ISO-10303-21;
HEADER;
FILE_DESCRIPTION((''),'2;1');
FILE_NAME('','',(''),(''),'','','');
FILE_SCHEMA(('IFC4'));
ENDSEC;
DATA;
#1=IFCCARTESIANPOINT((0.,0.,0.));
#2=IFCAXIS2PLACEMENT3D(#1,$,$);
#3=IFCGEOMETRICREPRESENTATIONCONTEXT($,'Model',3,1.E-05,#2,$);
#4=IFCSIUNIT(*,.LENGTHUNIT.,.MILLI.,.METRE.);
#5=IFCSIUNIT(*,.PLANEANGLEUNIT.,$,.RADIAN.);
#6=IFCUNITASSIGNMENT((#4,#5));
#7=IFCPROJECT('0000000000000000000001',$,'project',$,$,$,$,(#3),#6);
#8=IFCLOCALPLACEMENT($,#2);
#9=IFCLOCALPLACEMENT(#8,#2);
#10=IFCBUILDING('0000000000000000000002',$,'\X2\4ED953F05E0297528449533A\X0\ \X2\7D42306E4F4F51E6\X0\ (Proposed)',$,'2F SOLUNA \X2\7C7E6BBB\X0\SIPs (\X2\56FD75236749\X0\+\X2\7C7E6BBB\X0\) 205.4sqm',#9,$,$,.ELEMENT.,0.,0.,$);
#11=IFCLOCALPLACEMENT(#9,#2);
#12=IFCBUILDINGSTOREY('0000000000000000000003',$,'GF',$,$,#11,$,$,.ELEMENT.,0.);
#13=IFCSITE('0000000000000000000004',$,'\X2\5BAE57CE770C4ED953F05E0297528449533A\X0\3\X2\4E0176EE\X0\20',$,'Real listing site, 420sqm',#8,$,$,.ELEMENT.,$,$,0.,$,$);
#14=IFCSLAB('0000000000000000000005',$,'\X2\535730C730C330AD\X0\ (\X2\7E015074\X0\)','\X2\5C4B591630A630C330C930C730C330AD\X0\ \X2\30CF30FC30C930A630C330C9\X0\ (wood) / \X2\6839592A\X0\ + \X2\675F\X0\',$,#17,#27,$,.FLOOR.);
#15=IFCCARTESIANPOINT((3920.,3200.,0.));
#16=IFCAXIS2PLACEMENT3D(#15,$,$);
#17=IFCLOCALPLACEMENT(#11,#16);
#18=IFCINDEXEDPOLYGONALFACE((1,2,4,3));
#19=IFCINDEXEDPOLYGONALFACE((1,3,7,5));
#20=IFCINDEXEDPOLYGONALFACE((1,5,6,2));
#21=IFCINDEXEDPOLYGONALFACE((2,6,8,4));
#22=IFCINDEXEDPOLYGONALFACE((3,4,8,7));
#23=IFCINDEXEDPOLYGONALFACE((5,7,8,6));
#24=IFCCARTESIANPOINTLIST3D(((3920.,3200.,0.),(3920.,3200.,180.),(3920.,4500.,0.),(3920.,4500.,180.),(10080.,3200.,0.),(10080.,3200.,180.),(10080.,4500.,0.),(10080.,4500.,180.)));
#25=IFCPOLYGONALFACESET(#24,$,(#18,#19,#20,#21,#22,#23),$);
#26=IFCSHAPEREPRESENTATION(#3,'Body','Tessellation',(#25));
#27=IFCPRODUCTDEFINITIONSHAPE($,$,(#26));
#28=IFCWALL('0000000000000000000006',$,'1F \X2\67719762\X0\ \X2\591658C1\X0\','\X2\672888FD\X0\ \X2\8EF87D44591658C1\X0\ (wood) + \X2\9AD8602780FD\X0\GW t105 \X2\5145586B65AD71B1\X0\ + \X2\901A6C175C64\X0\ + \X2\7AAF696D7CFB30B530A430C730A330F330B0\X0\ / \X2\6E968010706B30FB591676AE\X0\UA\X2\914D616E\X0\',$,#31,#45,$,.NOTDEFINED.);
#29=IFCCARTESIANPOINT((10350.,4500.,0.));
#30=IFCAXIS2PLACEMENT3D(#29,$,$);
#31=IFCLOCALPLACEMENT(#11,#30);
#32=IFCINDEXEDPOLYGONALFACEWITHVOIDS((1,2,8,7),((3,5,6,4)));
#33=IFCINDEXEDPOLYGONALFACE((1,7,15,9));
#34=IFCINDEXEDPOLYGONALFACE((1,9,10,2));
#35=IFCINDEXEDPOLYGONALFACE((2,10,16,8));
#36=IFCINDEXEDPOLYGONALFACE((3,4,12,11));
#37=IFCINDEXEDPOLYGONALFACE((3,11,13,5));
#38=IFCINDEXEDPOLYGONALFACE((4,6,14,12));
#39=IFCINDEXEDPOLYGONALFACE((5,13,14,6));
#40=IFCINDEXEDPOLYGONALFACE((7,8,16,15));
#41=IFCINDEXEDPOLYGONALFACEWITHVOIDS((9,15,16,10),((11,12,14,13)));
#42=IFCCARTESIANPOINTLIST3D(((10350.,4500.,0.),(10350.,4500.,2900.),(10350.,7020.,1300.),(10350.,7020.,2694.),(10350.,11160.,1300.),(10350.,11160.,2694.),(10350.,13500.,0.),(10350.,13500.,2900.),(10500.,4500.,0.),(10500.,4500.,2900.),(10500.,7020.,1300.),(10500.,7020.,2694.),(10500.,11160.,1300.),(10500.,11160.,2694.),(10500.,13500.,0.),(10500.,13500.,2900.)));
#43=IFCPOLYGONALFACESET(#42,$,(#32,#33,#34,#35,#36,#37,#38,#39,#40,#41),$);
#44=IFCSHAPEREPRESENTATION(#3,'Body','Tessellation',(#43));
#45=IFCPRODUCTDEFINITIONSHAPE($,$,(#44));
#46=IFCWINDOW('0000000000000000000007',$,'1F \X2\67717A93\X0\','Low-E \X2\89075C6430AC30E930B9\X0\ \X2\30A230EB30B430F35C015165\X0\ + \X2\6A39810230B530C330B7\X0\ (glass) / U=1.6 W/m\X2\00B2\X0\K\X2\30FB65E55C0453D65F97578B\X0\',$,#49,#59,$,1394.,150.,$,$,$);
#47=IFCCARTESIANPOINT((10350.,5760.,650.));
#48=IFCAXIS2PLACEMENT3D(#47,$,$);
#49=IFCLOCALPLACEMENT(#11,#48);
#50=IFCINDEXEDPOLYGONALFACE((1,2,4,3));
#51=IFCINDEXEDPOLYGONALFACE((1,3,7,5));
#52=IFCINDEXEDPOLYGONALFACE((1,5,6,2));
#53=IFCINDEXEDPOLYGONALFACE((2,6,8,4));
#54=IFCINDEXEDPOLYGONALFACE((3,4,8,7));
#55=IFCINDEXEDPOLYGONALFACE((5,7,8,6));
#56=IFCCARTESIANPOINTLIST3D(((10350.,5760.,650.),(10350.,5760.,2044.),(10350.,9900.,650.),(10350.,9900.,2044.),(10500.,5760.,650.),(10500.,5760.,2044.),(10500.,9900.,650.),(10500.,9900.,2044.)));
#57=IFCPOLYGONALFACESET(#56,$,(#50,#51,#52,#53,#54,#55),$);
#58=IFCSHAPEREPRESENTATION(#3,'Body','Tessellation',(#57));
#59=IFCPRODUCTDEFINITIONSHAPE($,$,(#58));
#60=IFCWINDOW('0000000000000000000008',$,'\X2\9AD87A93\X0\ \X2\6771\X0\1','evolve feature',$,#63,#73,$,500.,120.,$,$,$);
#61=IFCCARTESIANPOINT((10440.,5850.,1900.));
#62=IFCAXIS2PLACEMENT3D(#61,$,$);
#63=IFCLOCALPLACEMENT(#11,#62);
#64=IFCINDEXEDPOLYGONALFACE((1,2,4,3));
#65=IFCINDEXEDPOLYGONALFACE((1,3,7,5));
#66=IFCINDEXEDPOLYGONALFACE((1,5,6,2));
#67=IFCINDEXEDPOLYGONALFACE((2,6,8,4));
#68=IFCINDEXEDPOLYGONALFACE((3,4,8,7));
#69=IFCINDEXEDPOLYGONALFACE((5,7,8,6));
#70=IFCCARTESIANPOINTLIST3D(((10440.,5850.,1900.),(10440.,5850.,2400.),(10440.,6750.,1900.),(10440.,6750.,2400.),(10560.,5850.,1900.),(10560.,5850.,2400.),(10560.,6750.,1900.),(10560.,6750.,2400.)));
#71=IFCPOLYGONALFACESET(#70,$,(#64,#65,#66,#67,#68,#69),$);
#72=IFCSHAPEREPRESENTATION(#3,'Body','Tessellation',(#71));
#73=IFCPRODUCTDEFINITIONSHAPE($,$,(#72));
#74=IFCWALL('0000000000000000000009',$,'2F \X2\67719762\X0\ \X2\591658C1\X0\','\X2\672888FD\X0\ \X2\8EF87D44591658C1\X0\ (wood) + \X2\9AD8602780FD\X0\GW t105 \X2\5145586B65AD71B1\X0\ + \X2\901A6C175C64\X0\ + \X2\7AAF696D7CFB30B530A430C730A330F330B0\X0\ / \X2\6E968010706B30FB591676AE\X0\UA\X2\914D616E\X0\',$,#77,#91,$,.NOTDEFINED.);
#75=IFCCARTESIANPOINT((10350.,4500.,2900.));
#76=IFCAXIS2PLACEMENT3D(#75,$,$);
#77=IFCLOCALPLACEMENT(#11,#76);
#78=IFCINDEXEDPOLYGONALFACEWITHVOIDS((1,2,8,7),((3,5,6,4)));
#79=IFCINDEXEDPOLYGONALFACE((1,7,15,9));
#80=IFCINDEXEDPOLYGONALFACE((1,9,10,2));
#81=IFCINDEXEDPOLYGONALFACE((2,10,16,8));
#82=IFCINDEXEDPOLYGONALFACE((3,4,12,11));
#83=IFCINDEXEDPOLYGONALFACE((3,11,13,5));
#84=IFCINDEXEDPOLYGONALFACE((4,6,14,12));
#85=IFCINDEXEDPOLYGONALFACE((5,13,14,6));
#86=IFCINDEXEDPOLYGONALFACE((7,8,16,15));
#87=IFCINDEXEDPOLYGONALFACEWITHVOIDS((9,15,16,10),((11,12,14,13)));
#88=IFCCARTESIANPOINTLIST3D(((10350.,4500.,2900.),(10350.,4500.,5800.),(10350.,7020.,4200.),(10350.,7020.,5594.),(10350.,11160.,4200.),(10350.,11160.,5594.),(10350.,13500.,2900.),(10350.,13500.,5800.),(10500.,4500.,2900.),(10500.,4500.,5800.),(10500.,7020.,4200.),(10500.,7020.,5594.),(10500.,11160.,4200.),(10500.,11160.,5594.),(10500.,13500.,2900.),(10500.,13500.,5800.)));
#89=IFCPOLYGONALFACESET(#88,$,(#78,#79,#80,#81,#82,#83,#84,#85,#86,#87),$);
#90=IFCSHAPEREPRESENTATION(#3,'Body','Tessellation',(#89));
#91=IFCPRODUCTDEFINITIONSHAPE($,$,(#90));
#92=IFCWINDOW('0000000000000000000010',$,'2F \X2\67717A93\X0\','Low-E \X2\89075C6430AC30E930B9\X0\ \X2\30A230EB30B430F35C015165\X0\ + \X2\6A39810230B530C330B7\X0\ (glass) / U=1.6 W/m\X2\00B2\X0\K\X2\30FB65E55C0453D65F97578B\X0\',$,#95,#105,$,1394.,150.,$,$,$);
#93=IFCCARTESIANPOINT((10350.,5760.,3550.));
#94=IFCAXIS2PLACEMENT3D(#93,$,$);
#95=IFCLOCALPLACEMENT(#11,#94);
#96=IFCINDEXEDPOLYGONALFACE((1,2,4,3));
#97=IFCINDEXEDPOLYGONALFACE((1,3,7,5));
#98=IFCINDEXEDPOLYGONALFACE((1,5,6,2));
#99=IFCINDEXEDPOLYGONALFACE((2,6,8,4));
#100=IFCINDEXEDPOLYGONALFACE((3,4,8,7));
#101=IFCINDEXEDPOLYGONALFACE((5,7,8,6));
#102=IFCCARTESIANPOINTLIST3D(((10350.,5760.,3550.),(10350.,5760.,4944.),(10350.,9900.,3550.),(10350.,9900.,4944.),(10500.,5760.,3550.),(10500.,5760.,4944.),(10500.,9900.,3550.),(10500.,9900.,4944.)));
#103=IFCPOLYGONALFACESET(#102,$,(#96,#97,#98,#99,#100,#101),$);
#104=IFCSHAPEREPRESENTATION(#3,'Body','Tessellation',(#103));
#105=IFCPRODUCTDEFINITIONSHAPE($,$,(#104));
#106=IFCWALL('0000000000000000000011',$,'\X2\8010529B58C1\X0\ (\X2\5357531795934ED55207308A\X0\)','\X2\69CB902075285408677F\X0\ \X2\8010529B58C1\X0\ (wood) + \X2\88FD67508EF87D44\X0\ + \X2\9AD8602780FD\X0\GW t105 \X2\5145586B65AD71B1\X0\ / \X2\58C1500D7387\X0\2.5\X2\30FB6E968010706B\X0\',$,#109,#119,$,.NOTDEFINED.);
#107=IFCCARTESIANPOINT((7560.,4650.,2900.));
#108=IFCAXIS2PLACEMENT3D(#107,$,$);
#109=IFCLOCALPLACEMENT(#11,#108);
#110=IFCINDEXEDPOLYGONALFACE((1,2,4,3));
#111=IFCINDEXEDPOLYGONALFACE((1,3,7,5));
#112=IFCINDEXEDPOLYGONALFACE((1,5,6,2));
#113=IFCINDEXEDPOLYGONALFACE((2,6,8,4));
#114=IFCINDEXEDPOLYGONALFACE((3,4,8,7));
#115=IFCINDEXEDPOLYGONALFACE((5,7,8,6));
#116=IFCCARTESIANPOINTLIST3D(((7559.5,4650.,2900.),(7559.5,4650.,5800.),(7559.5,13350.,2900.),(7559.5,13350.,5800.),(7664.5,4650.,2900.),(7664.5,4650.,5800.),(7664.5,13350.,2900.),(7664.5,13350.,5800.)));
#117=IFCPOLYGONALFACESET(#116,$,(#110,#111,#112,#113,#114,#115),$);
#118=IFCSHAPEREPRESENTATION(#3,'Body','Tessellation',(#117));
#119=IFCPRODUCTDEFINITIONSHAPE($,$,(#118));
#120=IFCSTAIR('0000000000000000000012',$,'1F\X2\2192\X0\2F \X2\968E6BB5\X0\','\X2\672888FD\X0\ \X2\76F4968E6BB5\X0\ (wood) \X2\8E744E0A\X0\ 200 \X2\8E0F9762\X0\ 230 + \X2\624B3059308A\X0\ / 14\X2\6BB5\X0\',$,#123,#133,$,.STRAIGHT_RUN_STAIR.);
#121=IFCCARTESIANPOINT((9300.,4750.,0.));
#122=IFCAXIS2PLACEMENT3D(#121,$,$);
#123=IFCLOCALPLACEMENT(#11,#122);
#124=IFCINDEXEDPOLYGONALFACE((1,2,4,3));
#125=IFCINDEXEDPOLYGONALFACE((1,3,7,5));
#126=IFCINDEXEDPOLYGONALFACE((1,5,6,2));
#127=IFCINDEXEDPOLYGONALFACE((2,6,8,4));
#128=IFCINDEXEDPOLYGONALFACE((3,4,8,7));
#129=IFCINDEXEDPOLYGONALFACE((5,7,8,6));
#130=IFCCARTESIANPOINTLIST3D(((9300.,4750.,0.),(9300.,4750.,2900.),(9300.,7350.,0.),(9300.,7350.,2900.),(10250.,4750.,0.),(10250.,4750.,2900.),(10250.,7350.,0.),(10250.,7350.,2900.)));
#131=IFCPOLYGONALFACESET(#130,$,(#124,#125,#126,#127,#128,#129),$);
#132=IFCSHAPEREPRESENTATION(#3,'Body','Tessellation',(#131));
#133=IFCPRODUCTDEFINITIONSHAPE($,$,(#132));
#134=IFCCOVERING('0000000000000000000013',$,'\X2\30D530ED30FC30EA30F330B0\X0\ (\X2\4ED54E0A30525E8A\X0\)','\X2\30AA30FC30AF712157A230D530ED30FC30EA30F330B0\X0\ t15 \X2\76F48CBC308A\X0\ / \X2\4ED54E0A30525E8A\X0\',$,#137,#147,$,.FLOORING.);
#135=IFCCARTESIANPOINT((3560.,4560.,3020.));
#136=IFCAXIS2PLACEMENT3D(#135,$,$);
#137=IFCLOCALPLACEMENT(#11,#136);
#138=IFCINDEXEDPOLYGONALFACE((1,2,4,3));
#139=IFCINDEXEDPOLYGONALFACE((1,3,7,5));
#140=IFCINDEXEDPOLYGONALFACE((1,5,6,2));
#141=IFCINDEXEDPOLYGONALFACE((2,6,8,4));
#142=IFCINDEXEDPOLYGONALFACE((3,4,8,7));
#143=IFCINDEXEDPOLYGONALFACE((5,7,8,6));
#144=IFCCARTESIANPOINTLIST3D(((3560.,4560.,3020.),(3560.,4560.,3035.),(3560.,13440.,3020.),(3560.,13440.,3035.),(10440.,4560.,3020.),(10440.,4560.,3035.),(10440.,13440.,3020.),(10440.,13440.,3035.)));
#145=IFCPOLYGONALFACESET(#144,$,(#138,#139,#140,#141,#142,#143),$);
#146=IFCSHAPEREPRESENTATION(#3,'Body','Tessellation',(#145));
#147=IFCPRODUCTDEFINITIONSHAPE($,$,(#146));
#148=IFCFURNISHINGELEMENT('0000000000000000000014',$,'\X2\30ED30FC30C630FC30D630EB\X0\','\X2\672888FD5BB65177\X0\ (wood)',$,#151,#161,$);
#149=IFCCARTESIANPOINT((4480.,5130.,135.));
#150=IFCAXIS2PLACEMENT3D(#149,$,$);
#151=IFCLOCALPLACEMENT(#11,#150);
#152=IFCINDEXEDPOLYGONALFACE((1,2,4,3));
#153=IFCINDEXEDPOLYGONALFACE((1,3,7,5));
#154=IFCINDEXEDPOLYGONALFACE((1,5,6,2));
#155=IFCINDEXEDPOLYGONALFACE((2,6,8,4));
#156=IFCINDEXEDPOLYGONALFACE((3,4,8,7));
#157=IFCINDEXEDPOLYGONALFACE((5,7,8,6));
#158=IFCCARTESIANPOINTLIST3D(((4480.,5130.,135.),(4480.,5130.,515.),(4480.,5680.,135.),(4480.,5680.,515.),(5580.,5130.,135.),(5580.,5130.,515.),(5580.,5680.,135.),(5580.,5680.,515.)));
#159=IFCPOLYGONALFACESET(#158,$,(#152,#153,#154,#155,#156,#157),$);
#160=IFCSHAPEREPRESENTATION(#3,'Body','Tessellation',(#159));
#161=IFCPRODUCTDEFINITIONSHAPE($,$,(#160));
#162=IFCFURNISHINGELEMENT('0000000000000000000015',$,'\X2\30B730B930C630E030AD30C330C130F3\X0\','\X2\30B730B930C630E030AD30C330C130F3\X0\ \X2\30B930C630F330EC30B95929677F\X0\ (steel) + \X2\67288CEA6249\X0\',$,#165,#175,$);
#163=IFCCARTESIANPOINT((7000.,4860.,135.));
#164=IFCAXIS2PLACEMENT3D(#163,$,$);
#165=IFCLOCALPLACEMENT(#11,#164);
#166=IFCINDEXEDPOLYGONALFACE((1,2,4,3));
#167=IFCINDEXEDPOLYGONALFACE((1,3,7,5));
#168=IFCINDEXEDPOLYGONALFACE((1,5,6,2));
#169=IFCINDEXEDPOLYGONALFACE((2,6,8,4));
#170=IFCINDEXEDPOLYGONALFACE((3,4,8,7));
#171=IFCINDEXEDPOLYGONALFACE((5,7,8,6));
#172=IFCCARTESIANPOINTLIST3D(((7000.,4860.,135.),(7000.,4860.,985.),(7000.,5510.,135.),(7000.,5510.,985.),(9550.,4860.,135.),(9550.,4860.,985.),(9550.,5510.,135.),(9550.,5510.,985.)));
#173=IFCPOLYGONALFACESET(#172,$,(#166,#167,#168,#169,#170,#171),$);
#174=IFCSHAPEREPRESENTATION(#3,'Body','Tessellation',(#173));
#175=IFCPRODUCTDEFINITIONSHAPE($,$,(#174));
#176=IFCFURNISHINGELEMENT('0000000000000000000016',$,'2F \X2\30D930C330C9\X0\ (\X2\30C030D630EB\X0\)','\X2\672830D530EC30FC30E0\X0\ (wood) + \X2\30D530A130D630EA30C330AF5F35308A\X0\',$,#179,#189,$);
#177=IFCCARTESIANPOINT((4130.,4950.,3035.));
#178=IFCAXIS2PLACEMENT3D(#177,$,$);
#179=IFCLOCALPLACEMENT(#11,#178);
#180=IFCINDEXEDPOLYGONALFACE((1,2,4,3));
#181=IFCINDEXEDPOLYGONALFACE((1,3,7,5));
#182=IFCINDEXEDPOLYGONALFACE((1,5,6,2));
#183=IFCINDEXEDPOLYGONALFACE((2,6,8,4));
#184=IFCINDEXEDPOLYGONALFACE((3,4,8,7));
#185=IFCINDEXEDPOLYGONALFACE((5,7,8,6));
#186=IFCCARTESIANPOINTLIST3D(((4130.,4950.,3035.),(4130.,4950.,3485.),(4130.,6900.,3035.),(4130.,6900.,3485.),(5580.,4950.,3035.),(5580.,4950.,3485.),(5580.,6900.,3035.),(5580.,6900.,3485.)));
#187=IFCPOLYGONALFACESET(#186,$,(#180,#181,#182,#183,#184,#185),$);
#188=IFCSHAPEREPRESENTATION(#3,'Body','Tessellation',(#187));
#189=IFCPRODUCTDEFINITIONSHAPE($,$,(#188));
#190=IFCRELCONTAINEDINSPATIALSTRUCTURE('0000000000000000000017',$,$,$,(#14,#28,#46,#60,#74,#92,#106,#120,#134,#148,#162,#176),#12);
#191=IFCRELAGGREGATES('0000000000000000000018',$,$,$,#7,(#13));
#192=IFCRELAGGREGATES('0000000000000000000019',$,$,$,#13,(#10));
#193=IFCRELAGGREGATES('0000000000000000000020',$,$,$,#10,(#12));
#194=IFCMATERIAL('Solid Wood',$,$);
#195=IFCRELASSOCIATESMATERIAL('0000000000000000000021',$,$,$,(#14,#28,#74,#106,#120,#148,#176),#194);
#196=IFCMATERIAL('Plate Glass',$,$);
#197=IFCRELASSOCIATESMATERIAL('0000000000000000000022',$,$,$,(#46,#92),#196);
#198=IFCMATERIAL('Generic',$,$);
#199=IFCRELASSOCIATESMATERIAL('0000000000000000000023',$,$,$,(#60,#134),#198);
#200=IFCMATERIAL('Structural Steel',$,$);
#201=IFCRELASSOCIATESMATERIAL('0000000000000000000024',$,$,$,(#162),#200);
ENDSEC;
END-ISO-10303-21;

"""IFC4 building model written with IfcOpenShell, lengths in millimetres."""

from ifc_helpers import new_model, si_unit, frame, frame_2d, origin, place, context, project, spatial, rectangle, extrude, material, element, fill, save


model = new_model("IFC4")

# Units and contexts
model_context = context("Model", 3, precision=1e-05, world=origin())
ifc_project = project(units=[si_unit("LENGTHUNIT", "METRE", prefix="MILLI"), si_unit("PLANEANGLEUNIT", "RADIAN")], contexts=[model_context])

# Site, building, storey
site_placement = place(None, origin())
site = spatial("IfcSite", under=ifc_project, at=site_placement, Name="宮城県仙台市青葉区3丁目20", ObjectType="Real listing site, 420sqm", CompositionType="ELEMENT", RefElevation=0.0)
building_placement = place(site_placement, origin())
building = spatial("IfcBuilding", under=site, at=building_placement, Name="仙台市青葉区 終の住処 (Proposed)", ObjectType="2F SOLUNA 籾殻SIPs (国産杉+籾殻) 205.4sqm", CompositionType="ELEMENT", ElevationOfRefHeight=0.0, ElevationOfTerrain=0.0)
storey_placement = place(building_placement, origin())
storey = spatial("IfcBuildingStorey", under=building, at=storey_placement, Name="GF", CompositionType="ELEMENT", Elevation=0.0)

# Slab
ifc_material_1 = material(Name="Solid Wood")
slab_placement = place(storey_placement, frame((3920.0, 3200.0, 0.0)))
element("IfcSlab", 1, at=slab_placement, inside=storey, material=ifc_material_1, Name="南デッキ (縁側)", Description="屋外ウッドデッキ ハードウッド (wood) / 根太 + 束", PredefinedType="FLOOR", context=model_context, shape_type="SweptSolid", body=[
    extrude(rectangle(XDim=6160.0, YDim=1300.0, at=frame_2d((3080.0, 650.0))), frame((3920.0, 3200.0, 0.0)), (0.0, 0.0, 1.0), 180.0),
])

# Wall, openings, windows
wall_1_placement = place(storey_placement, frame((10350.0, 4500.0, 0.0)))
wall_1 = element("IfcWall", 2, at=wall_1_placement, inside=storey, material=ifc_material_1, Name="1F 東面 外壁", Description="木製 軸組外壁 (wood) + 高性能GW t105 充填断熱 + 通気層 + 窯業系サイディング / 準耐火・外皮UA配慮", PredefinedType="NOTDEFINED", context=model_context, shape_type="SweptSolid", body=[
    extrude(rectangle(XDim=150.0, YDim=9000.0, at=frame_2d((75.0, 4500.0))), frame((10350.0, 4500.0, 0.0)), (0.0, 0.0, 1.0), 2900.0),
])
opening_1_placement = place(storey_placement, frame((10350.0, 5760.0, 650.0)))
opening_1 = element("IfcOpeningElement", 3, at=opening_1_placement, cuts=wall_1, PredefinedType="NOTDEFINED", context=model_context, shape_type="SweptSolid", body=[
    extrude(rectangle(XDim=150.0, YDim=4140.0, at=frame_2d((75.0, 2070.0))), frame((10350.0, 5760.0, 650.0)), (0.0, 0.0, 1.0), 1394.0),
])
opening_2_placement = place(storey_placement, frame((10440.0, 5850.0, 1900.0)))
opening_2 = element("IfcOpeningElement", 4, at=opening_2_placement, cuts=wall_1, PredefinedType="NOTDEFINED", context=model_context, shape_type="SweptSolid", body=[
    extrude(rectangle(XDim=120.0, YDim=900.0, at=frame_2d((60.0, 450.0))), frame((10440.0, 5850.0, 1900.0)), (0.0, 0.0, 1.0), 500.0),
])
ifc_material_2 = material(Name="Plate Glass")
window_1_placement = place(storey_placement, frame((10350.0, 5760.0, 650.0)))
window_1 = element("IfcWindow", 5, at=window_1_placement, inside=storey, material=ifc_material_2, Name="1F 東窓", Description="Low-E 複層ガラス アルゴン封入 + 樹脂サッシ (glass) / U=1.6 W/m²K・日射取得型", OverallHeight=1394.0, OverallWidth=150.0, context=model_context, shape_type="SweptSolid", body=[
    extrude(rectangle(XDim=150.0, YDim=4140.0, at=frame_2d((75.0, 2070.0))), frame((10350.0, 5760.0, 650.0)), (0.0, 0.0, 1.0), 1394.0),
])
fill(opening_1, window_1)
ifc_material_3 = material(Name="Generic")
window_2_placement = place(storey_placement, frame((10440.0, 5850.0, 1900.0)))
window_2 = element("IfcWindow", 6, at=window_2_placement, inside=storey, material=ifc_material_3, Name="高窓 東1", Description="evolve feature", OverallHeight=500.0, OverallWidth=120.0, context=model_context, shape_type="SweptSolid", body=[
    extrude(rectangle(XDim=120.0, YDim=900.0, at=frame_2d((60.0, 450.0))), frame((10440.0, 5850.0, 1900.0)), (0.0, 0.0, 1.0), 500.0),
])
fill(opening_2, window_2)

# Wall, opening, window
wall_2_placement = place(storey_placement, frame((10350.0, 4500.0, 2900.0)))
wall_2 = element("IfcWall", 7, at=wall_2_placement, inside=storey, material=ifc_material_1, Name="2F 東面 外壁", Description="木製 軸組外壁 (wood) + 高性能GW t105 充填断熱 + 通気層 + 窯業系サイディング / 準耐火・外皮UA配慮", PredefinedType="NOTDEFINED", context=model_context, shape_type="SweptSolid", body=[
    extrude(rectangle(XDim=150.0, YDim=9000.0, at=frame_2d((75.0, 4500.0))), frame((10350.0, 4500.0, 2900.0)), (0.0, 0.0, 1.0), 2900.0),
])
opening_3_placement = place(storey_placement, frame((10350.0, 5760.0, 3550.0)))
opening_3 = element("IfcOpeningElement", 8, at=opening_3_placement, cuts=wall_2, PredefinedType="NOTDEFINED", context=model_context, shape_type="SweptSolid", body=[
    extrude(rectangle(XDim=150.0, YDim=4140.0, at=frame_2d((75.0, 2070.0))), frame((10350.0, 5760.0, 3550.0)), (0.0, 0.0, 1.0), 1394.0),
])
window_3_placement = place(storey_placement, frame((10350.0, 5760.0, 3550.0)))
window_3 = element("IfcWindow", 9, at=window_3_placement, inside=storey, material=ifc_material_2, Name="2F 東窓", Description="Low-E 複層ガラス アルゴン封入 + 樹脂サッシ (glass) / U=1.6 W/m²K・日射取得型", OverallHeight=1394.0, OverallWidth=150.0, context=model_context, shape_type="SweptSolid", body=[
    extrude(rectangle(XDim=150.0, YDim=4140.0, at=frame_2d((75.0, 2070.0))), frame((10350.0, 5760.0, 3550.0)), (0.0, 0.0, 1.0), 1394.0),
])
fill(opening_3, window_3)

# Wall
wall_3_placement = place(storey_placement, frame((7560.0, 4650.0, 2900.0)))
element("IfcWall", 10, at=wall_3_placement, inside=storey, material=ifc_material_1, Name="耐力壁 (南北間仕切り)", Description="構造用合板 耐力壁 (wood) + 製材軸組 + 高性能GW t105 充填断熱 / 壁倍率2.5・準耐火", PredefinedType="NOTDEFINED", context=model_context, shape_type="SweptSolid", body=[
    extrude(rectangle(XDim=105.0, YDim=8700.0, at=frame_2d((52.0, 4350.0))), frame((7560.0, 4650.0, 2900.0)), (0.0, 0.0, 1.0), 2900.0),
])

# Stair
stair_placement = place(storey_placement, frame((9300.0, 4750.0, 0.0)))
element("IfcStair", 11, at=stair_placement, inside=storey, material=ifc_material_1, Name="1F→2F 階段", Description="木製 直階段 (wood) 蹴上 200 踏面 230 + 手すり / 14段", PredefinedType="STRAIGHT_RUN_STAIR", context=model_context, shape_type="SweptSolid", body=[
    extrude(rectangle(XDim=950.0, YDim=2600.0, at=frame_2d((475.0, 1300.0))), frame((9300.0, 4750.0, 0.0)), (0.0, 0.0, 1.0), 2900.0),
])

# Covering
covering_placement = place(storey_placement, frame((3560.0, 4560.0, 3020.0)))
element("IfcCovering", 12, at=covering_placement, inside=storey, material=ifc_material_3, Name="フローリング (仕上げ床)", Description="オーク無垢フローリング t15 直貼り / 仕上げ床", PredefinedType="FLOORING", context=model_context, shape_type="SweptSolid", body=[
    extrude(rectangle(XDim=6880.0, YDim=8880.0, at=frame_2d((3440.0, 4440.0))), frame((3560.0, 4560.0, 3020.0)), (0.0, 0.0, 1.0), 15.0),
])

# Furnishing elements
furnishing_1_placement = place(storey_placement, frame((4480.0, 5130.0, 135.0)))
element("IfcFurnishingElement", 13, at=furnishing_1_placement, inside=storey, material=ifc_material_1, Name="ローテーブル", Description="木製家具 (wood)", context=model_context, shape_type="SweptSolid", body=[
    extrude(rectangle(XDim=1100.0, YDim=550.0, at=frame_2d((550.0, 275.0))), frame((4480.0, 5130.0, 135.0)), (0.0, 0.0, 1.0), 380.0),
])
ifc_material_4 = material(Name="Structural Steel")
furnishing_2_placement = place(storey_placement, frame((7000.0, 4860.0, 135.0)))
element("IfcFurnishingElement", 14, at=furnishing_2_placement, inside=storey, material=ifc_material_4, Name="システムキッチン", Description="システムキッチン ステンレス天板 (steel) + 木質扉", context=model_context, shape_type="SweptSolid", body=[
    extrude(rectangle(XDim=2550.0, YDim=650.0, at=frame_2d((1275.0, 325.0))), frame((7000.0, 4860.0, 135.0)), (0.0, 0.0, 1.0), 850.0),
])
furnishing_3_placement = place(storey_placement, frame((4130.0, 4950.0, 3035.0)))
element("IfcFurnishingElement", 15, at=furnishing_3_placement, inside=storey, material=ifc_material_1, Name="2F ベッド (ダブル)", Description="木フレーム (wood) + ファブリック張り", context=model_context, shape_type="SweptSolid", body=[
    extrude(rectangle(XDim=1450.0, YDim=1950.0, at=frame_2d((725.0, 975.0))), frame((4130.0, 4950.0, 3035.0)), (0.0, 0.0, 1.0), 450.0),
])

save(model, "model.ifc")
